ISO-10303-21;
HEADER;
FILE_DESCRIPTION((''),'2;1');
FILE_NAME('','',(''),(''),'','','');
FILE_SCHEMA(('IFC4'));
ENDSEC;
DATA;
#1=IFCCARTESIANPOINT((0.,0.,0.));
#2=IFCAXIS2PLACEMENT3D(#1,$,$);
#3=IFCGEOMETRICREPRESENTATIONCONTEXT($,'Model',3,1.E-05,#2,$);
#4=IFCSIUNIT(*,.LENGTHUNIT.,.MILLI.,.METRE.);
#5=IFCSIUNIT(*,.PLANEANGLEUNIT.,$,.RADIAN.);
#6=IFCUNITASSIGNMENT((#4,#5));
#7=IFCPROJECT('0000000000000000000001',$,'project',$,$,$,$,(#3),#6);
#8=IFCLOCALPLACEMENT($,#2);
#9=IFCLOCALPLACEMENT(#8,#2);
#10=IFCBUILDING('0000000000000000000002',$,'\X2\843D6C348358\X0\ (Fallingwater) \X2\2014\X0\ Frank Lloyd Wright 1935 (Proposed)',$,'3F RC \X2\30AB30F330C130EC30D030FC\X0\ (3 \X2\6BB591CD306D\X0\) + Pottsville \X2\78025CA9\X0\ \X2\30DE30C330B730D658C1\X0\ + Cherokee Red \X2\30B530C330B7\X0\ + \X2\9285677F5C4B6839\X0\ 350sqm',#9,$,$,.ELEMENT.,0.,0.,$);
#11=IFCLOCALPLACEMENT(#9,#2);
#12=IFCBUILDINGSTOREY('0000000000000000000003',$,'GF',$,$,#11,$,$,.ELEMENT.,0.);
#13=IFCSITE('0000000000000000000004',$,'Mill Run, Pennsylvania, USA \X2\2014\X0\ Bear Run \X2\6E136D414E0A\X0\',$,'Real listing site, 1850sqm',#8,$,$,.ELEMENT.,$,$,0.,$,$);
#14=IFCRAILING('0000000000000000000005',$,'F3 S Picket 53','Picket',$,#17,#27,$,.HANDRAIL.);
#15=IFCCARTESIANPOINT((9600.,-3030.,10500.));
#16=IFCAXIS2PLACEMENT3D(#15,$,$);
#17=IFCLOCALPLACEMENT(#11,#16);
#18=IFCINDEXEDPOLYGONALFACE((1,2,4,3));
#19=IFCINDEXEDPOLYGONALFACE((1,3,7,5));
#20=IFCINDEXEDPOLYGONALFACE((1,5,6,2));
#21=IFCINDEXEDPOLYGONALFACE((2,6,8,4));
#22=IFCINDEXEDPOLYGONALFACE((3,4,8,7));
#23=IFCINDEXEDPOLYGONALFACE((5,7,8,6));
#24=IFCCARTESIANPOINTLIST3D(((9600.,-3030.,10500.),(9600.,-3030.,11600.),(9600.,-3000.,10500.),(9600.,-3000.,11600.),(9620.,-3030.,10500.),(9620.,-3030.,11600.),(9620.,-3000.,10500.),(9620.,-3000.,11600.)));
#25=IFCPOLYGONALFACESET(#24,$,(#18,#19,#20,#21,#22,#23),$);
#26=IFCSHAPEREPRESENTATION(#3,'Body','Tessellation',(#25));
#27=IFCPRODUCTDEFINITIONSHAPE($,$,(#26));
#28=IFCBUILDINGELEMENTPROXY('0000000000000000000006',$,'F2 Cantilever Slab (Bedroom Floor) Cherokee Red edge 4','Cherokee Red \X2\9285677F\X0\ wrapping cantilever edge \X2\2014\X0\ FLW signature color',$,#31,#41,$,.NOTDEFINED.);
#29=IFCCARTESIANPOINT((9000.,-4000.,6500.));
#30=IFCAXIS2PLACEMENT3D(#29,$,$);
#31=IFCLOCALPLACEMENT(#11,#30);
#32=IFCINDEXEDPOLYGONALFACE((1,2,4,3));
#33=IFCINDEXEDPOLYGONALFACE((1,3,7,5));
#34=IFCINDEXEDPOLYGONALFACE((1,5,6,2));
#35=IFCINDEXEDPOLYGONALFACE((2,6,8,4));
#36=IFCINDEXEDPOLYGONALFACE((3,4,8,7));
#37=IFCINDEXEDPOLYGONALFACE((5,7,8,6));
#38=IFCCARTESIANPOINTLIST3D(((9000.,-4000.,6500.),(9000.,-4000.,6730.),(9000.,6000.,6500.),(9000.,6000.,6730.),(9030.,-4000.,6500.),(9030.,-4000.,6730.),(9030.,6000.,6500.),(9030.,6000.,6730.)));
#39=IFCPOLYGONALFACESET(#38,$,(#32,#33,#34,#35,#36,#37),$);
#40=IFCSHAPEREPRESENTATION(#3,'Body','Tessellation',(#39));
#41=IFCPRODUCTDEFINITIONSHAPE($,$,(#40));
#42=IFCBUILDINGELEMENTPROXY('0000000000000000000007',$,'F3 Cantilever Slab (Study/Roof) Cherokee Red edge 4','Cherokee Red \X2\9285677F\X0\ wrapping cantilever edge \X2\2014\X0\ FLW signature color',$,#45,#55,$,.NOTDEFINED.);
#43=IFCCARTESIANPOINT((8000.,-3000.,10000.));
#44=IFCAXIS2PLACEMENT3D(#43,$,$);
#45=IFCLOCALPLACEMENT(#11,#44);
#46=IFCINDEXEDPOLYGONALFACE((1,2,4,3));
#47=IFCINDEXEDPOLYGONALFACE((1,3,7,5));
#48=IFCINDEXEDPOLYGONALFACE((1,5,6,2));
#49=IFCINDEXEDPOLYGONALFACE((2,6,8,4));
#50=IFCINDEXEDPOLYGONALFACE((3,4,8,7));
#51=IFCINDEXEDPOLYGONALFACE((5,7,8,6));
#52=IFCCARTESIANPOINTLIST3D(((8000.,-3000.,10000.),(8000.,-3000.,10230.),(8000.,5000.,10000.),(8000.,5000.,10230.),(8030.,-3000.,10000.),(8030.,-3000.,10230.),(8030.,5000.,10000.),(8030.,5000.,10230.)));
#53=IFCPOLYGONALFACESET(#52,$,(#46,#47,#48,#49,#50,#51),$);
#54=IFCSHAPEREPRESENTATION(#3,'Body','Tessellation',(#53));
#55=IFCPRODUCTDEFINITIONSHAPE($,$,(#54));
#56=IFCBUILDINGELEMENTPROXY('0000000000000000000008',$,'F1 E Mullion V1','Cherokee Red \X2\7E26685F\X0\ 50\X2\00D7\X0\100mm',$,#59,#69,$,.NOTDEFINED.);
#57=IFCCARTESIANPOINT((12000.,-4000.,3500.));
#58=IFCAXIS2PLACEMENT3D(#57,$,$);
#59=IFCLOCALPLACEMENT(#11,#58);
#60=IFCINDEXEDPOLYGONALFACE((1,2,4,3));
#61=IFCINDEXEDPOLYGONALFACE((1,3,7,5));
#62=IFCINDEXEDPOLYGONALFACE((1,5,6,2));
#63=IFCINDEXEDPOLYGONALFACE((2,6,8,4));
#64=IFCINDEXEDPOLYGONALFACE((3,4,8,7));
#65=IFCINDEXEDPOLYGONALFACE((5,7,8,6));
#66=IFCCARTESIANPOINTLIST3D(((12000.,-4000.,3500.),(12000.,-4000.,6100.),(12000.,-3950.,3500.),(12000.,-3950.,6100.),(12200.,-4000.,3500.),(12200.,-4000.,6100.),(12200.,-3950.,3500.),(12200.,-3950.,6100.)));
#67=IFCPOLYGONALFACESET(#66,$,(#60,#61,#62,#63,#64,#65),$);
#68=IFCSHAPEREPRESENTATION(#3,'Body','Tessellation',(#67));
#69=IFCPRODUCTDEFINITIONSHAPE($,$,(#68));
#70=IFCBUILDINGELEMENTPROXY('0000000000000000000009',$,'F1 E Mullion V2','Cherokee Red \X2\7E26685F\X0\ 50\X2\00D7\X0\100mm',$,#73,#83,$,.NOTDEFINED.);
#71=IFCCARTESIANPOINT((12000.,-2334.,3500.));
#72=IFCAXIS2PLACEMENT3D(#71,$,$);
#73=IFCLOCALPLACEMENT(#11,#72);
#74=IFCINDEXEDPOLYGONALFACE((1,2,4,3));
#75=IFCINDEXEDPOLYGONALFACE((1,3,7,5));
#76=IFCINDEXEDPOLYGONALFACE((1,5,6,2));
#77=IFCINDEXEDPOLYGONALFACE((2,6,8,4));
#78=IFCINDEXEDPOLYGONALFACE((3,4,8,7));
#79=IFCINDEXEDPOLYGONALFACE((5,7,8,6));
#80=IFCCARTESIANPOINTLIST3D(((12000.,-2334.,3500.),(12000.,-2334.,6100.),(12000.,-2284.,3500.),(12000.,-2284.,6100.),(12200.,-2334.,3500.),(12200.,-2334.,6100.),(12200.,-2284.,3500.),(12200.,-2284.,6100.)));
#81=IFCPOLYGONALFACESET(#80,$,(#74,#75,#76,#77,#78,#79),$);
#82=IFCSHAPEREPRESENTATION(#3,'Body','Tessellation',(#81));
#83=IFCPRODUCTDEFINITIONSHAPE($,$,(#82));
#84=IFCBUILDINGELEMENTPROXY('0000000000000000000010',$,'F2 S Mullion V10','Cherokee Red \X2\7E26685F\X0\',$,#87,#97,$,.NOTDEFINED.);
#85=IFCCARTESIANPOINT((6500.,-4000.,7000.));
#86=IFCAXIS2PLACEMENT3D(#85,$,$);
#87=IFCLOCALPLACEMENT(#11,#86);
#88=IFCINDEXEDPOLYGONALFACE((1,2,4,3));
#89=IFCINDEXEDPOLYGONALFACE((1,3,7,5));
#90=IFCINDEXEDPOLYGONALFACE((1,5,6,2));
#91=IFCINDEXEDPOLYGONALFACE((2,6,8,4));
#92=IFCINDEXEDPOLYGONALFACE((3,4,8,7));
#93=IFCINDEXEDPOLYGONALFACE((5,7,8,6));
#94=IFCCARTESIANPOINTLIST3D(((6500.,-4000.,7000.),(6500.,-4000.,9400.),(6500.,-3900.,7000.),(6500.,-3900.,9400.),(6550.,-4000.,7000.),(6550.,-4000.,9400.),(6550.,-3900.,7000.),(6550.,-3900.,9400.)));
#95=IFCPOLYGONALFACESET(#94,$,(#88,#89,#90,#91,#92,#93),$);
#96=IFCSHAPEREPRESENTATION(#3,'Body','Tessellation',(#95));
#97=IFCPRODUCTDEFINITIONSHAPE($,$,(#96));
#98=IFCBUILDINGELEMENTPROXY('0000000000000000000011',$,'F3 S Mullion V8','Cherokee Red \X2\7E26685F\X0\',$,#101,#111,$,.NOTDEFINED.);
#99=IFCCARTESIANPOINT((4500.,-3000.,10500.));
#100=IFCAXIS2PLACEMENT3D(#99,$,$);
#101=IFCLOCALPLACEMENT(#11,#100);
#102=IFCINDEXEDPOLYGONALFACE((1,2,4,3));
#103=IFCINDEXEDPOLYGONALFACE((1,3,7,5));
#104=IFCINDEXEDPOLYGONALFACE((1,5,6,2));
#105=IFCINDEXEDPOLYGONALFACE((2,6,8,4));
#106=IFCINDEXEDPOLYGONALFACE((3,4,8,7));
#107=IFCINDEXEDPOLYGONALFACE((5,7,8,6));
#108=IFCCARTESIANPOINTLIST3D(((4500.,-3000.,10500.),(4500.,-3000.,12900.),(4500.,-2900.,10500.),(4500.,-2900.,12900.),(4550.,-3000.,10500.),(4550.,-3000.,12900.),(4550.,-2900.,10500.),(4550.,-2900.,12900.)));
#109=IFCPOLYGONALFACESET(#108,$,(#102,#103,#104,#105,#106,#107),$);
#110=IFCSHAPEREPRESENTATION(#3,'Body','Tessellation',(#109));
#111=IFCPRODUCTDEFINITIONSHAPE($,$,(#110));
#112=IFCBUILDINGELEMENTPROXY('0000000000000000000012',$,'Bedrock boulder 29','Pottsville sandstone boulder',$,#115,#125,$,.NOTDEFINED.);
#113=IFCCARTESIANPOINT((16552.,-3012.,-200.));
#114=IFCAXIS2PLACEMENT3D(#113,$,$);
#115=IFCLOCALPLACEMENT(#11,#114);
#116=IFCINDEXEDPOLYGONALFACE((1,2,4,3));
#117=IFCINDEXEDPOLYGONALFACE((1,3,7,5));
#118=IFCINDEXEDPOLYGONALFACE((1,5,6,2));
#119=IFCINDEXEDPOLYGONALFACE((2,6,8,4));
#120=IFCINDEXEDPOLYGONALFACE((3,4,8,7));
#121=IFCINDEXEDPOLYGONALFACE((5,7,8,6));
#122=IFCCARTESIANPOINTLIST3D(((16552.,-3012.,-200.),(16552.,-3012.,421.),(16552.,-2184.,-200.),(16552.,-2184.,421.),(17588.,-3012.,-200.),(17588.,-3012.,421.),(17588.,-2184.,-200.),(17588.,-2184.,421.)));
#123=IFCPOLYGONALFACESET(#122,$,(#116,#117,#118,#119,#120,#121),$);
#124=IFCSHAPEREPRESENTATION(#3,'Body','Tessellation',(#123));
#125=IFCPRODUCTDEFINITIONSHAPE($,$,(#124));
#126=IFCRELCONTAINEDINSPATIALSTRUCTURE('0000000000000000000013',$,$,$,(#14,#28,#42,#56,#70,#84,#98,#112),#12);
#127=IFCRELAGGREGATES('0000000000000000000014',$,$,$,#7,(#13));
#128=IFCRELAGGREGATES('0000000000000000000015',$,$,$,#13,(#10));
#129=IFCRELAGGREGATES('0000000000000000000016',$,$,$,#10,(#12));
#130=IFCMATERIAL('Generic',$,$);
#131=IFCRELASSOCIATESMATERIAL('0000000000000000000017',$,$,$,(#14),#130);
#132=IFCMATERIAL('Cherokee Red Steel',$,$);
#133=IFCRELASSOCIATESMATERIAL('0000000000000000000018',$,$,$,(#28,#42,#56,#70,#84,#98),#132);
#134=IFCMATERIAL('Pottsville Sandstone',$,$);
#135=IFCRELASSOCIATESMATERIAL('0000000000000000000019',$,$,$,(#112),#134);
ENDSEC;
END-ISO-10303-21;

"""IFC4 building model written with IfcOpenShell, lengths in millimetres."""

from ifc_helpers import new_model, si_unit, frame, frame_2d, origin, place, context, project, spatial, rectangle, extrude, material, element, save


model = new_model("IFC4")

# Units and contexts
model_context = context("Model", 3, precision=1e-05, world=origin())
ifc_project = project(units=[si_unit("LENGTHUNIT", "METRE", prefix="MILLI"), si_unit("PLANEANGLEUNIT", "RADIAN")], contexts=[model_context])

# Site, building, storey
site_placement = place(None, origin())
site = spatial("IfcSite", under=ifc_project, at=site_placement, Name="Mill Run, Pennsylvania, USA — Bear Run 渓流上", ObjectType="Real listing site, 1850sqm", CompositionType="ELEMENT", RefElevation=0.0)
building_placement = place(site_placement, origin())
building = spatial("IfcBuilding", under=site, at=building_placement, Name="落水荘 (Fallingwater) — Frank Lloyd Wright 1935 (Proposed)", ObjectType="3F RC カンチレバー (3 段重ね) + Pottsville 砂岩 マッシブ壁 + Cherokee Red サッシ + 銅板屋根 350sqm", CompositionType="ELEMENT", ElevationOfRefHeight=0.0, ElevationOfTerrain=0.0)
storey_placement = place(building_placement, origin())
storey = spatial("IfcBuildingStorey", under=building, at=storey_placement, Name="GF", CompositionType="ELEMENT", Elevation=0.0)

# Railing
ifc_material_1 = material(Name="Cherokee Red Steel")
ifc_material_2 = material(Name="Generic")
railing_1_placement = place(storey_placement, frame((9600.0, -3030.0, 10500.0)))
element("IfcRailing", 1, at=railing_1_placement, inside=storey, material=ifc_material_2, Name="F3 S Picket 53", Description="Picket", PredefinedType="HANDRAIL", context=model_context, shape_type="SweptSolid", body=[
    extrude(rectangle(XDim=20.0, YDim=30.0, at=frame_2d((10.0, 15.0))), frame((9600.0, -3030.0, 10500.0)), (0.0, 0.0, 1.0), 1100.0),
])

# Building element proxies
proxy_1_placement = place(storey_placement, frame((9000.0, -4000.0, 6500.0)))
element("IfcBuildingElementProxy", 2, at=proxy_1_placement, inside=storey, material=ifc_material_1, Name="F2 Cantilever Slab (Bedroom Floor) Cherokee Red edge 4", Description="Cherokee Red 銅板 wrapping cantilever edge — FLW signature color", PredefinedType="NOTDEFINED", context=model_context, shape_type="SweptSolid", body=[
    extrude(rectangle(XDim=30.0, YDim=10000.0, at=frame_2d((15.0, 5000.0))), frame((9000.0, -4000.0, 6500.0)), (0.0, 0.0, 1.0), 230.0),
])
proxy_2_placement = place(storey_placement, frame((8000.0, -3000.0, 10000.0)))
element("IfcBuildingElementProxy", 3, at=proxy_2_placement, inside=storey, material=ifc_material_1, Name="F3 Cantilever Slab (Study/Roof) Cherokee Red edge 4", Description="Cherokee Red 銅板 wrapping cantilever edge — FLW signature color", PredefinedType="NOTDEFINED", context=model_context, shape_type="SweptSolid", body=[
    extrude(rectangle(XDim=30.0, YDim=8000.0, at=frame_2d((15.0, 4000.0))), frame((8000.0, -3000.0, 10000.0)), (0.0, 0.0, 1.0), 230.0),
])
proxy_3_placement = place(storey_placement, frame((12000.0, -4000.0, 3500.0)))
element("IfcBuildingElementProxy", 4, at=proxy_3_placement, inside=storey, material=ifc_material_1, Name="F1 E Mullion V1", Description="Cherokee Red 縦桟 50×100mm", PredefinedType="NOTDEFINED", context=model_context, shape_type="SweptSolid", body=[
    extrude(rectangle(XDim=200.0, YDim=50.0, at=frame_2d((100.0, 25.0))), frame((12000.0, -4000.0, 3500.0)), (0.0, 0.0, 1.0), 2600.0),
])
proxy_4_placement = place(storey_placement, frame((12000.0, -2334.0, 3500.0)))
element("IfcBuildingElementProxy", 5, at=proxy_4_placement, inside=storey, material=ifc_material_1, Name="F1 E Mullion V2", Description="Cherokee Red 縦桟 50×100mm", PredefinedType="NOTDEFINED", context=model_context, shape_type="SweptSolid", body=[
    extrude(rectangle(XDim=200.0, YDim=50.0, at=frame_2d((100.0, 25.0))), frame((12000.0, -2334.0, 3500.0)), (0.0, 0.0, 1.0), 2600.0),
])
proxy_5_placement = place(storey_placement, frame((6500.0, -4000.0, 7000.0)))
element("IfcBuildingElementProxy", 6, at=proxy_5_placement, inside=storey, material=ifc_material_1, Name="F2 S Mullion V10", Description="Cherokee Red 縦桟", PredefinedType="NOTDEFINED", context=model_context, shape_type="SweptSolid", body=[
    extrude(rectangle(XDim=50.0, YDim=100.0, at=frame_2d((25.0, 50.0))), frame((6500.0, -4000.0, 7000.0)), (0.0, 0.0, 1.0), 2400.0),
])
proxy_6_placement = place(storey_placement, frame((4500.0, -3000.0, 10500.0)))
element("IfcBuildingElementProxy", 7, at=proxy_6_placement, inside=storey, material=ifc_material_1, Name="F3 S Mullion V8", Description="Cherokee Red 縦桟", PredefinedType="NOTDEFINED", context=model_context, shape_type="SweptSolid", body=[
    extrude(rectangle(XDim=50.0, YDim=100.0, at=frame_2d((25.0, 50.0))), frame((4500.0, -3000.0, 10500.0)), (0.0, 0.0, 1.0), 2400.0),
])
ifc_material_3 = material(Name="Pottsville Sandstone")
proxy_7_placement = place(storey_placement, frame((16552.0, -3012.0, -200.0)))
element("IfcBuildingElementProxy", 8, at=proxy_7_placement, inside=storey, material=ifc_material_3, Name="Bedrock boulder 29", Description="Pottsville sandstone boulder", PredefinedType="NOTDEFINED", context=model_context, shape_type="SweptSolid", body=[
    extrude(rectangle(XDim=1036.0, YDim=828.0, at=frame_2d((518.0, 414.0))), frame((16552.0, -3012.0, -200.0)), (0.0, 0.0, 1.0), 621.0),
])

save(model, "model.ifc")
